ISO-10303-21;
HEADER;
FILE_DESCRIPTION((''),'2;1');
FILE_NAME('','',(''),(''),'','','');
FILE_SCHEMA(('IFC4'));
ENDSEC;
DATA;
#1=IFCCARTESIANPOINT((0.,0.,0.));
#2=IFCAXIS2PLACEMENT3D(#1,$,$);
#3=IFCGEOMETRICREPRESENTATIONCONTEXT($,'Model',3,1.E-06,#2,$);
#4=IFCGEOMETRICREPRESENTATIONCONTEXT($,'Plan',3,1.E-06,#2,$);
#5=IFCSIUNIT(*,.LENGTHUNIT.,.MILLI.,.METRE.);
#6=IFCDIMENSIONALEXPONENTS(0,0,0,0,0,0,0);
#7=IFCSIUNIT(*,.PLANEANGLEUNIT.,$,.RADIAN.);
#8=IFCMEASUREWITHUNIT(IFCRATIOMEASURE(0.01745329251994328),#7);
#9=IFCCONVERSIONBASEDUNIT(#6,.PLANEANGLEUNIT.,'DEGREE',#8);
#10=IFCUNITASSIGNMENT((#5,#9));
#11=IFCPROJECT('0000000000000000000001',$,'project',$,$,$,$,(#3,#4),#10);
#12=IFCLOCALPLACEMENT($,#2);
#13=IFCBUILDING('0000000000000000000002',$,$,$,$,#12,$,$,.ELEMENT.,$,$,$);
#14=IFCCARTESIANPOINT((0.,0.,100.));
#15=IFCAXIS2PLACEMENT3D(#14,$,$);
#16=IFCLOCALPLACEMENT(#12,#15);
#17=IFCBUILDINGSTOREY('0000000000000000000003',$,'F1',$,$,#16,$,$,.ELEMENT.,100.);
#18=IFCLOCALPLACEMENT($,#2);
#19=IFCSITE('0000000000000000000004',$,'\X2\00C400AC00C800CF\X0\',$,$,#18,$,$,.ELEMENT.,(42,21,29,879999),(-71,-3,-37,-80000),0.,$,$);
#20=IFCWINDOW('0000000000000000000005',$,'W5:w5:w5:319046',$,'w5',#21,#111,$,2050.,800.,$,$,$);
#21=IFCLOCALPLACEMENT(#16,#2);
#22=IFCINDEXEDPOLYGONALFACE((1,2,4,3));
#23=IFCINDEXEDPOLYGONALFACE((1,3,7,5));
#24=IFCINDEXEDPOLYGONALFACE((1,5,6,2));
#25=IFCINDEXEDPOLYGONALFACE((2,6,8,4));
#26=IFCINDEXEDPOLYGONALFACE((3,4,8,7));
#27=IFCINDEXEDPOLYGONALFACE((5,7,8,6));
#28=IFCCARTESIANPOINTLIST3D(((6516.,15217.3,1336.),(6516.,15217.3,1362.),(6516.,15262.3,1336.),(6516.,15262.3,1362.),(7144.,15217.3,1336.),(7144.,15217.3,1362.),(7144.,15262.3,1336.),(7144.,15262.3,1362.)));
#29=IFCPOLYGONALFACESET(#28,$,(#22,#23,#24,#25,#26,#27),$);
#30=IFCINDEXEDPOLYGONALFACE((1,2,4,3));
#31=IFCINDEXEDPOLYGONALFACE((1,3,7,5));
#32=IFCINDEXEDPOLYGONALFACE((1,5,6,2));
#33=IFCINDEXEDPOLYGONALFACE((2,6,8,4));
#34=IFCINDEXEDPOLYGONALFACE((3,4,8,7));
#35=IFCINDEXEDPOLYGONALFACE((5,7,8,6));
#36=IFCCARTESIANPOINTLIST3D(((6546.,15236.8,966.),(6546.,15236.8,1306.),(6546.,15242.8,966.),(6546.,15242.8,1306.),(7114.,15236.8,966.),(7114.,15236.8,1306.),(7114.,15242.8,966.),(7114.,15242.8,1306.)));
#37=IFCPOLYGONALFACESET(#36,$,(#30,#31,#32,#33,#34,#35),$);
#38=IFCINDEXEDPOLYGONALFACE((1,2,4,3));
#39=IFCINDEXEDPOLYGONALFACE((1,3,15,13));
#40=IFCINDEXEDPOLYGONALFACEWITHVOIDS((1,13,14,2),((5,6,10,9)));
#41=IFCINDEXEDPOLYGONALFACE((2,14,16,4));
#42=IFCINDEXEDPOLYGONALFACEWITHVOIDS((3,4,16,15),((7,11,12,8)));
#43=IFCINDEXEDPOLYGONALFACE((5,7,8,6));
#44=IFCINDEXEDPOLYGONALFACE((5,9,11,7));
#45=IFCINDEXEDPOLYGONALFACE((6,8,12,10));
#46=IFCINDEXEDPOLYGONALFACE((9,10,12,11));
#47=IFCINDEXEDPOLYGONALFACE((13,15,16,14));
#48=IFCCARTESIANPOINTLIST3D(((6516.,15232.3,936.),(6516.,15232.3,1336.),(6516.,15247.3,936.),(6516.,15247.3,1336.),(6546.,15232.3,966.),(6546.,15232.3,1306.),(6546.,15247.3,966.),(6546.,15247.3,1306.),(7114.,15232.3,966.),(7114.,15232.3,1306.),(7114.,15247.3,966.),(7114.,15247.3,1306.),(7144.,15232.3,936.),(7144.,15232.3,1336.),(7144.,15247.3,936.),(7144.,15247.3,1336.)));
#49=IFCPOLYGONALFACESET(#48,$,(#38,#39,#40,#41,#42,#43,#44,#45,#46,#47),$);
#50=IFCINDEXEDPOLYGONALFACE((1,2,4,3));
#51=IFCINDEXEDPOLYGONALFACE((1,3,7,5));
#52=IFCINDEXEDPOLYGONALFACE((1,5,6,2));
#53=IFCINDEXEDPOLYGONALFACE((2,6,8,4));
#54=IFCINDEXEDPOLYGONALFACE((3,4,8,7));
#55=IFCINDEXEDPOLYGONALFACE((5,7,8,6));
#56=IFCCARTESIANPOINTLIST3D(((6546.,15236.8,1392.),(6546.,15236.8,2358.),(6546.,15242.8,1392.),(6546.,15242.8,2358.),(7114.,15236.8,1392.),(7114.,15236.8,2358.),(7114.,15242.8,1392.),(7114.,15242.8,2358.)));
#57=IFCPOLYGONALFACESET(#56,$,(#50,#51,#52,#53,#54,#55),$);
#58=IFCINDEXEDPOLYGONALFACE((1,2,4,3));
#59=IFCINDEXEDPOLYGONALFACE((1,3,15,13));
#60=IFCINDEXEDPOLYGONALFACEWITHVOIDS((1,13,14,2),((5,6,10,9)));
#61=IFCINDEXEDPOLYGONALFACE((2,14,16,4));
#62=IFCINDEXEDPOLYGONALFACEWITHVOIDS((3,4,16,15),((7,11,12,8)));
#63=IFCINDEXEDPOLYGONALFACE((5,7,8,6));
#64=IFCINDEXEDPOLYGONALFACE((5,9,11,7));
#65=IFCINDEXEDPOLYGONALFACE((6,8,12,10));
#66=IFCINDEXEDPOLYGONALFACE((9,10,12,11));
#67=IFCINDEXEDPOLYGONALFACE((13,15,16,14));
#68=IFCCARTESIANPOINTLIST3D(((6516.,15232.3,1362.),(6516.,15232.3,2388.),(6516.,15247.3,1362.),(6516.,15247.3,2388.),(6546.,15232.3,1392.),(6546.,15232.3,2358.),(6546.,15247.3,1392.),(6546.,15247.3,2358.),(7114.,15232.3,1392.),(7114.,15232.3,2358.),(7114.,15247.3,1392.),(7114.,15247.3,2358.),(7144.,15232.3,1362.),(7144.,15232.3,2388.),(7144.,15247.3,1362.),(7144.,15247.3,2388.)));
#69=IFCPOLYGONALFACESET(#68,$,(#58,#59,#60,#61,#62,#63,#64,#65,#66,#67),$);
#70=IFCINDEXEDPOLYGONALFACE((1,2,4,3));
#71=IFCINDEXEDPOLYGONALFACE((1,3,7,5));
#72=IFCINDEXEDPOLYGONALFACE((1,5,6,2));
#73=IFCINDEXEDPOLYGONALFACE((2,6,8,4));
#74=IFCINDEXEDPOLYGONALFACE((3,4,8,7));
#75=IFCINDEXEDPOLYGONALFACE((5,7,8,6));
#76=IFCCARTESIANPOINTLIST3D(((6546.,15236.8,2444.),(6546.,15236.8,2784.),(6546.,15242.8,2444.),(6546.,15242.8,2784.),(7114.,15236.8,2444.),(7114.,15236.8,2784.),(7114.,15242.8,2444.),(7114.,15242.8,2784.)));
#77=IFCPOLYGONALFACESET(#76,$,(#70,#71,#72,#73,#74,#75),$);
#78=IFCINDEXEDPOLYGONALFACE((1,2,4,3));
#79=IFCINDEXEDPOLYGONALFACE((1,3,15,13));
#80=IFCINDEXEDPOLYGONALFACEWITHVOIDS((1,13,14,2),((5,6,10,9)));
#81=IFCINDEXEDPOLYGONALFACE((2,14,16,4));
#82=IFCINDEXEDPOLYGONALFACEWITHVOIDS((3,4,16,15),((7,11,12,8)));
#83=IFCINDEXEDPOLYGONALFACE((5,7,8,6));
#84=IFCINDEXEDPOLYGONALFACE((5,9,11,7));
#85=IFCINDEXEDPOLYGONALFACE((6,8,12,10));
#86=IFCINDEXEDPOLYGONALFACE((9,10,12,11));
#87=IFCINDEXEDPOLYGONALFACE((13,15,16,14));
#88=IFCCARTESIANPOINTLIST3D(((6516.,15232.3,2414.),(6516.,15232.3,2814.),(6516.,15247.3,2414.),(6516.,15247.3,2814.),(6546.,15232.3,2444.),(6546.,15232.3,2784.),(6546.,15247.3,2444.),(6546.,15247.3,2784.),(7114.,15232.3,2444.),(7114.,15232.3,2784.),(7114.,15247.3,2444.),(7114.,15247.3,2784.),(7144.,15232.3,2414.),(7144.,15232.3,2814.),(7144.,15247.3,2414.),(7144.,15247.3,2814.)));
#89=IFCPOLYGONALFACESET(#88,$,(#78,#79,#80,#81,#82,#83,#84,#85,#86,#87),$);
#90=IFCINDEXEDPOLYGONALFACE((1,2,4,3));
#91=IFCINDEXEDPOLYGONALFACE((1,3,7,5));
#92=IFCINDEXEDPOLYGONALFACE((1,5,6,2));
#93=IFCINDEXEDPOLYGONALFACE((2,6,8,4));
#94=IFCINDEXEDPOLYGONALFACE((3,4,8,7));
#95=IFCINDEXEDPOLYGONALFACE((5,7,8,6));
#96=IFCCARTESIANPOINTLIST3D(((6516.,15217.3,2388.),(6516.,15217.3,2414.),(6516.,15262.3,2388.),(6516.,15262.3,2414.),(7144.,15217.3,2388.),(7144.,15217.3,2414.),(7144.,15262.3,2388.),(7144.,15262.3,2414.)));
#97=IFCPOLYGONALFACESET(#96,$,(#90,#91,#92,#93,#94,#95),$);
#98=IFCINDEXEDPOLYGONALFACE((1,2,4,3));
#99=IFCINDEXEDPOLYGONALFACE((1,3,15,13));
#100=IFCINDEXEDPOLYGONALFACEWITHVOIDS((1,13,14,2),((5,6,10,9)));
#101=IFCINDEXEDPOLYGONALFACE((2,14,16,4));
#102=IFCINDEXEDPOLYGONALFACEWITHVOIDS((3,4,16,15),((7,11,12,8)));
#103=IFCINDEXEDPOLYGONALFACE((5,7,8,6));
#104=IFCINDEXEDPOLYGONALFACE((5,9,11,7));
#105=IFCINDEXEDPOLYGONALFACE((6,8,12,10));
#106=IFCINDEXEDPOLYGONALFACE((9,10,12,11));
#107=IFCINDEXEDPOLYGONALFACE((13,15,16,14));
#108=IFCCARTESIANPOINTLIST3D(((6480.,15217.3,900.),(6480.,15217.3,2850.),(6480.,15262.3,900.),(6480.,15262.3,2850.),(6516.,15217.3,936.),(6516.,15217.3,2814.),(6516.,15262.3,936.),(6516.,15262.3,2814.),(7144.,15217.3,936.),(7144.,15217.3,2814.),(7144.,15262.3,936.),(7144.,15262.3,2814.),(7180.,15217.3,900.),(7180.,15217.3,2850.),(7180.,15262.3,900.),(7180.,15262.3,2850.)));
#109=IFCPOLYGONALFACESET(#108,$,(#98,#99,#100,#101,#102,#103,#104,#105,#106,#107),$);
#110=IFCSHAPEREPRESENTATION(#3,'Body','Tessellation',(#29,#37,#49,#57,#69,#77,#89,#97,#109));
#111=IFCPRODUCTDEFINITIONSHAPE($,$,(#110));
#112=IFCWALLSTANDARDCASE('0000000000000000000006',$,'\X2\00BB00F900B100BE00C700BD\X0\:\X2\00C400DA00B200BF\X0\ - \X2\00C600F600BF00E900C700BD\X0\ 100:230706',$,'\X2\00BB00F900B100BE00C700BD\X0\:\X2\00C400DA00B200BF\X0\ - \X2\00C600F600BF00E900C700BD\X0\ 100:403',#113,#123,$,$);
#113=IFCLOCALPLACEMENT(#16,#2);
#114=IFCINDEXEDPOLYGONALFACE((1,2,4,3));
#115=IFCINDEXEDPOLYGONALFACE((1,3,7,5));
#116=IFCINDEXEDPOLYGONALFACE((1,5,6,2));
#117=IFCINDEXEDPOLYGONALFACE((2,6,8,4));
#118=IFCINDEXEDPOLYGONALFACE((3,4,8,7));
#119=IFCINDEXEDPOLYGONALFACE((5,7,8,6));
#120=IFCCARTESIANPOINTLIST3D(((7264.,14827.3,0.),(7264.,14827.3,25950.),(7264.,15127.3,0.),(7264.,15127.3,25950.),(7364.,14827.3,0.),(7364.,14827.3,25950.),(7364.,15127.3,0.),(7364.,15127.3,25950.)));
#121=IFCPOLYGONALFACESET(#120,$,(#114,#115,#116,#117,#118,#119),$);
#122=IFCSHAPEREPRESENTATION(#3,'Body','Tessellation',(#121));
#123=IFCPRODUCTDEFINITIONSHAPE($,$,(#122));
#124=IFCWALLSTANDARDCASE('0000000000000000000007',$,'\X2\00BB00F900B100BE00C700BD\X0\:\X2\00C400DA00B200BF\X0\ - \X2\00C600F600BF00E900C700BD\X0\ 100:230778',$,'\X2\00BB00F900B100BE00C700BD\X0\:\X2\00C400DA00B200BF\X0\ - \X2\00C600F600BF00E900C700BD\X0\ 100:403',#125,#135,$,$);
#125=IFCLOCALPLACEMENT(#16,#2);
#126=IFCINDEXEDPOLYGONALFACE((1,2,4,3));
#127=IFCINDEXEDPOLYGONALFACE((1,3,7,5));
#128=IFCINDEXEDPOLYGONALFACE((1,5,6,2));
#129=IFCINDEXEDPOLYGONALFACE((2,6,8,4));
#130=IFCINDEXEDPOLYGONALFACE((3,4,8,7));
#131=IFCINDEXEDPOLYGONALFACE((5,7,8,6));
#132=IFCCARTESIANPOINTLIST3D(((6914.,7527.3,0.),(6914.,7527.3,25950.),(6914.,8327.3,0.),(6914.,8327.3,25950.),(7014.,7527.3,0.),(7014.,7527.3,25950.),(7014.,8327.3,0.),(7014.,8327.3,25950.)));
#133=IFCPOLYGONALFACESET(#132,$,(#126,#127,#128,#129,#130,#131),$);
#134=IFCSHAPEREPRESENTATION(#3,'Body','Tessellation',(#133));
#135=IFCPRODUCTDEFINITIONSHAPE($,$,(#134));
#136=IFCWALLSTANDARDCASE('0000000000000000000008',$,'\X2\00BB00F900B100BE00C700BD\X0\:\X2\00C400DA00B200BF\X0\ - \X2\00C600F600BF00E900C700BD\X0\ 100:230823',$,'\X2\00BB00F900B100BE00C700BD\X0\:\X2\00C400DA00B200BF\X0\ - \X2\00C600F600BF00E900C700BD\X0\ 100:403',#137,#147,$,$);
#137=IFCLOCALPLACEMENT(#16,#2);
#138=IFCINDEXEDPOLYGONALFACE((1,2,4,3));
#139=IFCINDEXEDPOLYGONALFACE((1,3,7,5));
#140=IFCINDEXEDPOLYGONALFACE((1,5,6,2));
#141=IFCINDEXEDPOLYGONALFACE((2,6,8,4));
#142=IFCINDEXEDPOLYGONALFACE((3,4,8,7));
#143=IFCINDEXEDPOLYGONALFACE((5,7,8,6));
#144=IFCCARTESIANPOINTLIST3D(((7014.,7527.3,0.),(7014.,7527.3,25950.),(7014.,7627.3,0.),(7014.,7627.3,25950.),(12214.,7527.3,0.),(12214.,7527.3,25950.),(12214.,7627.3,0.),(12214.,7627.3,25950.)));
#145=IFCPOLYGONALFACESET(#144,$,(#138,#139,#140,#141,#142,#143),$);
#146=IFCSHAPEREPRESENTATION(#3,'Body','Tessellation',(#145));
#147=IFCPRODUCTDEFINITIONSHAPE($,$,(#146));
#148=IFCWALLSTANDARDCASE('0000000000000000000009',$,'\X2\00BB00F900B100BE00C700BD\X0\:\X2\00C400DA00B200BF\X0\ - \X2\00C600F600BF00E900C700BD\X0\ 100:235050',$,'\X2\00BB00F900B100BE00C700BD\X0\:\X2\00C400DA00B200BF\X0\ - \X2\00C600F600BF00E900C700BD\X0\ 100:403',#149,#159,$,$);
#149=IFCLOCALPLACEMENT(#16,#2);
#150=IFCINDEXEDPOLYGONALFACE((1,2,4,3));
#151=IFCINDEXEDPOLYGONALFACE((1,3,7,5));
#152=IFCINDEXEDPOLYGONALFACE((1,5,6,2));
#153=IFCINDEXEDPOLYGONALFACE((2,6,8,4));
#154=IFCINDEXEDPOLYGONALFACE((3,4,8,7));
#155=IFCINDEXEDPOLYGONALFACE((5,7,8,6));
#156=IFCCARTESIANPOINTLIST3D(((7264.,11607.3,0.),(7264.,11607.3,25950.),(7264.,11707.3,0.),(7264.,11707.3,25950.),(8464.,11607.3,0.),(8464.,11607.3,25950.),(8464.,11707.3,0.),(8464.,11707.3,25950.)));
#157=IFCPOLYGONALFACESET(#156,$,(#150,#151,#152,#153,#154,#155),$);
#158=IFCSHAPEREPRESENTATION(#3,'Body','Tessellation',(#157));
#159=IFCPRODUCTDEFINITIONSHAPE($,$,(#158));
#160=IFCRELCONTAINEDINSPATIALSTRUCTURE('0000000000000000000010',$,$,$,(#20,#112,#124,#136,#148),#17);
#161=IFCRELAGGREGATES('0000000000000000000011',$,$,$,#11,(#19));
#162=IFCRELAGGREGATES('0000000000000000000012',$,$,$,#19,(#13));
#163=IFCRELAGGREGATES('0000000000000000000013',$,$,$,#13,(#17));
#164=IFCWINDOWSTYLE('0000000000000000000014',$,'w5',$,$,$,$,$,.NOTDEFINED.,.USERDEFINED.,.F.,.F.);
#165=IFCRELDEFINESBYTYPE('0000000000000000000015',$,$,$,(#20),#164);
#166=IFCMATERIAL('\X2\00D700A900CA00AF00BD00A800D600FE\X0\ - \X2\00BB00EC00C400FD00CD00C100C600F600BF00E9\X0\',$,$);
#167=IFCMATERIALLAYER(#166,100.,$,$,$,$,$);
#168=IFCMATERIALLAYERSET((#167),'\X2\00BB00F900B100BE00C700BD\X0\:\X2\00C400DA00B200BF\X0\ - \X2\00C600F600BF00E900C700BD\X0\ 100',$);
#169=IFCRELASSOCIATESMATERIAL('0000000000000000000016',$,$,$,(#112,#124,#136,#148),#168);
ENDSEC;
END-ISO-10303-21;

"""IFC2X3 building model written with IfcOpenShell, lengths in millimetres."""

from ifc_helpers import new_model, entity, si_unit, converted_unit, frame, frame_2d, origin, origin_2d_with_axis, place, context, project, spatial, polyline, rectangle, outline, extrude, clip, bounded_halfspace, source, transform, mapped, material, layer, layer_set, layer_usage, type_object, type_shapes, element, save


model = new_model("IFC2X3")

# Units and contexts
model_context = context("Model", 3, precision=1e-06, world=origin())
plan_context = context("Plan", 3, precision=1e-06, world=origin())
ifc_project = project(units=[si_unit("LENGTHUNIT", "METRE", prefix="MILLI"), converted_unit("PLANEANGLEUNIT", "DEGREE", entity("IfcRatioMeasure", 0.01745329251994328), si_unit("PLANEANGLEUNIT", "RADIAN"), dimensions=[0, 0, 0, 0, 0, 0, 0])], contexts=[model_context, plan_context])

# Site, building, storey
site_placement = place(None, origin())
site = spatial("IfcSite", under=ifc_project, at=site_placement, Name="Ä¬ÈÏ", CompositionType="ELEMENT", RefLatitude=(42, 21, 29, 879999), RefLongitude=(-71, -3, -37, -80000), RefElevation=0.0)
building_placement = place(None, origin())
building = spatial("IfcBuilding", under=site, at=building_placement, CompositionType="ELEMENT")
storey_placement = place(building_placement, frame((0.0, 0.0, 100.0)))
storey = spatial("IfcBuildingStorey", under=building, at=storey_placement, Name="F1", CompositionType="ELEMENT", Elevation=100.0)

# Window
window_style = type_object("IfcWindowStyle", Name="w5", ConstructionType="NOTDEFINED", OperationType="USERDEFINED", ParameterTakesPrecedence=False, Sizeable=False)
shared_shape_1 = source(origin(), model_context, "Body", "SweptSolid", [
    extrude(rectangle(XDim=45.0, YDim=628.0, at=origin_2d_with_axis()), frame((350.0, -248.1, 436.0), z_axis=(0.0, 0.0, 1.0), x_axis=(0.0, 1.0, 0.0)), (0.0, 0.0, 1.0), 26.0),
    extrude(rectangle(XDim=6.0, YDim=568.0, at=origin_2d_with_axis()), frame((350.0, -248.1, 66.0), z_axis=(0.0, 0.0, 1.0), x_axis=(0.0, 1.0, 0.0)), (0.0, 0.0, 1.0), 340.0),
    extrude(outline(polyline([(-200.0, -314.0), (200.0, -314.0), (200.0, 314.0), (-200.0, 314.0), (-200.0, -314.0)]), holes=[polyline([(170.0, -284.0), (-170.0, -284.0), (-170.0, 284.0), (170.0, 284.0), (170.0, -284.0)])]), frame((350.0, -255.6, 236.0), z_axis=(0.0, 1.0, 0.0), x_axis=(0.0, 0.0, 1.0)), (0.0, 0.0, 1.0), 15.0),
    extrude(rectangle(XDim=6.0, YDim=568.0, at=origin_2d_with_axis()), frame((350.0, -248.1, 492.0), z_axis=(0.0, 0.0, 1.0), x_axis=(0.0, 1.0, 0.0)), (0.0, 0.0, 1.0), 966.0),
    extrude(outline(polyline([(-513.0, -314.0), (513.0, -314.0), (513.0, 314.0), (-513.0, 314.0), (-513.0, -314.0)]), holes=[polyline([(483.0, -284.0), (-483.0, -284.0), (-483.0, 284.0), (483.0, 284.0), (483.0, -284.0)])]), frame((350.0, -255.6, 975.0), z_axis=(0.0, 1.0, 0.0), x_axis=(0.0, 0.0, 1.0)), (0.0, 0.0, 1.0), 15.0),
    extrude(rectangle(XDim=6.0, YDim=568.0, at=origin_2d_with_axis()), frame((350.0, -248.1, 1544.0), z_axis=(0.0, 0.0, 1.0), x_axis=(0.0, 1.0, 0.0)), (0.0, 0.0, 1.0), 340.0),
    extrude(outline(polyline([(-200.0, -314.0), (200.0, -314.0), (200.0, 314.0), (-200.0, 314.0), (-200.0, -314.0)]), holes=[polyline([(170.0, -284.0), (-170.0, -284.0), (-170.0, 284.0), (170.0, 284.0), (170.0, -284.0)])]), frame((350.0, -255.6, 1714.0), z_axis=(0.0, 1.0, 0.0), x_axis=(0.0, 0.0, 1.0)), (0.0, 0.0, 1.0), 15.0),
    extrude(rectangle(XDim=45.0, YDim=628.0, at=origin_2d_with_axis()), frame((350.0, -248.1, 1488.0), z_axis=(0.0, 0.0, 1.0), x_axis=(0.0, 1.0, 0.0)), (0.0, 0.0, 1.0), 26.0),
    extrude(outline(polyline([(-975.0, -350.0), (975.0, -350.0), (975.0, 350.0), (-975.0, 350.0), (-975.0, -350.0)]), holes=[polyline([(939.0, -314.0), (-939.0, -314.0), (-939.0, 314.0), (939.0, 314.0), (939.0, -314.0)])]), frame((350.0, -270.6, 975.0), z_axis=(0.0, 1.0, 0.0), x_axis=(0.0, 0.0, 1.0)), (0.0, 0.0, 1.0), 45.0),
])
type_shapes(window_style, [shared_shape_1])
window_placement = place(storey_placement, frame((6480.0, 15487.9, 900.0)))
element("IfcWindow", 1, at=window_placement, inside=storey, type_object=window_style, Name="W5:w5:w5:319046", ObjectType="w5", OverallHeight=2050.0, OverallWidth=800.0, context=model_context, shape_type="MappedRepresentation", body=[
    mapped(shared_shape_1, transform((0.0, 0.0, 0.0), scale=1.0)),
])

# Walls
ifc_material_1 = material(Name="×©Ê¯½¨Öþ - »ìÄýÍÁÆö¿é")
ifc_layer_1 = layer(ifc_material_1, 100.0)
ifc_layer_set_1 = layer_set([ifc_layer_1], Name="»ù±¾Ç½:ÄÚ²¿ - Æö¿éÇ½ 100")
ifc_layer_usage_1 = layer_usage(ifc_layer_set_1, "AXIS2", "NEGATIVE", 50.0)
wall_1_placement = place(storey_placement, frame((7314.0, 14827.3, 0.0), z_axis=(0.0, 0.0, 1.0), x_axis=(0.0, 1.0, 0.0)))
element("IfcWallStandardCase", 2, at=wall_1_placement, inside=storey, material=ifc_layer_usage_1, Name="»ù±¾Ç½:ÄÚ²¿ - Æö¿éÇ½ 100:230706", ObjectType="»ù±¾Ç½:ÄÚ²¿ - Æö¿éÇ½ 100:403", context=model_context, shape_type="Clipping", body=[
    clip(extrude(rectangle(XDim=300.0, YDim=100.0, at=frame_2d((150.0, 0.0), x_axis=(-1.0, 0.0))), origin(), (0.0, 0.0, 1.0), 25950.0), bounded_halfspace(frame((0.0, -50.0, 25950.0), z_axis=(0.0, 0.0, -1.0), x_axis=(0.0, -1.0, 0.0)), True, frame((0.0, -50.0, 25950.0)), polyline([(0.0, 0.0), (300.0, 0.0), (300.0, 100.0), (200.0, 100.0), (0.0, 100.0), (0.0, 0.0)]))),
])
ifc_layer_usage_2 = layer_usage(ifc_layer_set_1, "AXIS2", "NEGATIVE", 50.0)
wall_2_placement = place(storey_placement, frame((6964.0, 8327.3, 0.0), z_axis=(0.0, 0.0, 1.0), x_axis=(0.0, -1.0, 0.0)))
element("IfcWallStandardCase", 3, at=wall_2_placement, inside=storey, material=ifc_layer_usage_2, Name="»ù±¾Ç½:ÄÚ²¿ - Æö¿éÇ½ 100:230778", ObjectType="»ù±¾Ç½:ÄÚ²¿ - Æö¿éÇ½ 100:403", context=model_context, shape_type="Clipping", body=[
    clip(extrude(rectangle(XDim=800.0, YDim=100.0, at=frame_2d((400.0, 0.0), x_axis=(-1.0, 0.0))), origin(), (0.0, 0.0, 1.0), 25950.0), bounded_halfspace(frame((0.0, -50.0, 25950.0), z_axis=(0.0, 0.0, -1.0), x_axis=(0.0, 1.0, 0.0)), True, frame((0.0, -50.0, 25950.0)), polyline([(0.0, 0.0), (800.0, 0.0), (800.0, 100.0), (700.0, 100.0), (0.0, 100.0), (0.0, 0.0)]))),
])
ifc_layer_usage_3 = layer_usage(ifc_layer_set_1, "AXIS2", "NEGATIVE", 50.0)
wall_3_placement = place(storey_placement, frame((7014.0, 7577.3, 0.0)))
element("IfcWallStandardCase", 4, at=wall_3_placement, inside=storey, material=ifc_layer_usage_3, Name="»ù±¾Ç½:ÄÚ²¿ - Æö¿éÇ½ 100:230823", ObjectType="»ù±¾Ç½:ÄÚ²¿ - Æö¿éÇ½ 100:403", context=model_context, shape_type="Clipping", body=[
    clip(extrude(rectangle(XDim=5200.0, YDim=100.0, at=frame_2d((2600.0, 0.0), x_axis=(-1.0, 0.0))), origin(), (0.0, 0.0, 1.0), 25950.0), bounded_halfspace(frame((0.0, -50.0, 25950.0), z_axis=(0.0, 0.0, -1.0), x_axis=(1.0, 0.0, 0.0)), True, frame((0.0, -50.0, 25950.0)), polyline([(0.0, 0.0), (4000.0, 0.0), (4900.0, 0.0), (5100.0, 0.0), (5200.0, 0.0), (5200.0, 100.0), (4900.0, 100.0), (4000.0, 100.0), (0.0, 100.0), (0.0, 0.0)]))),
])
ifc_layer_usage_4 = layer_usage(ifc_layer_set_1, "AXIS2", "NEGATIVE", 50.0)
wall_4_placement = place(storey_placement, frame((8464.0, 11657.3, 0.0), z_axis=(0.0, 0.0, 1.0), x_axis=(-1.0, 0.0, 0.0)))
element("IfcWallStandardCase", 5, at=wall_4_placement, inside=storey, material=ifc_layer_usage_4, Name="»ù±¾Ç½:ÄÚ²¿ - Æö¿éÇ½ 100:235050", ObjectType="»ù±¾Ç½:ÄÚ²¿ - Æö¿éÇ½ 100:403", context=model_context, shape_type="Clipping", body=[
    clip(extrude(rectangle(XDim=1200.0, YDim=100.0, at=frame_2d((600.0, 0.0), x_axis=(-1.0, 0.0))), origin(), (0.0, 0.0, 1.0), 25950.0), bounded_halfspace(frame((0.0, -50.0, 25950.0), z_axis=(0.0, 0.0, -1.0), x_axis=(-1.0, 0.0, 0.0)), True, frame((0.0, -50.0, 25950.0)), polyline([(0.0, 0.0), (1200.0, 0.0), (1200.0, 100.0), (100.0, 100.0), (0.0, 100.0), (0.0, 0.0)]))),
])

save(model, "model.ifc")
